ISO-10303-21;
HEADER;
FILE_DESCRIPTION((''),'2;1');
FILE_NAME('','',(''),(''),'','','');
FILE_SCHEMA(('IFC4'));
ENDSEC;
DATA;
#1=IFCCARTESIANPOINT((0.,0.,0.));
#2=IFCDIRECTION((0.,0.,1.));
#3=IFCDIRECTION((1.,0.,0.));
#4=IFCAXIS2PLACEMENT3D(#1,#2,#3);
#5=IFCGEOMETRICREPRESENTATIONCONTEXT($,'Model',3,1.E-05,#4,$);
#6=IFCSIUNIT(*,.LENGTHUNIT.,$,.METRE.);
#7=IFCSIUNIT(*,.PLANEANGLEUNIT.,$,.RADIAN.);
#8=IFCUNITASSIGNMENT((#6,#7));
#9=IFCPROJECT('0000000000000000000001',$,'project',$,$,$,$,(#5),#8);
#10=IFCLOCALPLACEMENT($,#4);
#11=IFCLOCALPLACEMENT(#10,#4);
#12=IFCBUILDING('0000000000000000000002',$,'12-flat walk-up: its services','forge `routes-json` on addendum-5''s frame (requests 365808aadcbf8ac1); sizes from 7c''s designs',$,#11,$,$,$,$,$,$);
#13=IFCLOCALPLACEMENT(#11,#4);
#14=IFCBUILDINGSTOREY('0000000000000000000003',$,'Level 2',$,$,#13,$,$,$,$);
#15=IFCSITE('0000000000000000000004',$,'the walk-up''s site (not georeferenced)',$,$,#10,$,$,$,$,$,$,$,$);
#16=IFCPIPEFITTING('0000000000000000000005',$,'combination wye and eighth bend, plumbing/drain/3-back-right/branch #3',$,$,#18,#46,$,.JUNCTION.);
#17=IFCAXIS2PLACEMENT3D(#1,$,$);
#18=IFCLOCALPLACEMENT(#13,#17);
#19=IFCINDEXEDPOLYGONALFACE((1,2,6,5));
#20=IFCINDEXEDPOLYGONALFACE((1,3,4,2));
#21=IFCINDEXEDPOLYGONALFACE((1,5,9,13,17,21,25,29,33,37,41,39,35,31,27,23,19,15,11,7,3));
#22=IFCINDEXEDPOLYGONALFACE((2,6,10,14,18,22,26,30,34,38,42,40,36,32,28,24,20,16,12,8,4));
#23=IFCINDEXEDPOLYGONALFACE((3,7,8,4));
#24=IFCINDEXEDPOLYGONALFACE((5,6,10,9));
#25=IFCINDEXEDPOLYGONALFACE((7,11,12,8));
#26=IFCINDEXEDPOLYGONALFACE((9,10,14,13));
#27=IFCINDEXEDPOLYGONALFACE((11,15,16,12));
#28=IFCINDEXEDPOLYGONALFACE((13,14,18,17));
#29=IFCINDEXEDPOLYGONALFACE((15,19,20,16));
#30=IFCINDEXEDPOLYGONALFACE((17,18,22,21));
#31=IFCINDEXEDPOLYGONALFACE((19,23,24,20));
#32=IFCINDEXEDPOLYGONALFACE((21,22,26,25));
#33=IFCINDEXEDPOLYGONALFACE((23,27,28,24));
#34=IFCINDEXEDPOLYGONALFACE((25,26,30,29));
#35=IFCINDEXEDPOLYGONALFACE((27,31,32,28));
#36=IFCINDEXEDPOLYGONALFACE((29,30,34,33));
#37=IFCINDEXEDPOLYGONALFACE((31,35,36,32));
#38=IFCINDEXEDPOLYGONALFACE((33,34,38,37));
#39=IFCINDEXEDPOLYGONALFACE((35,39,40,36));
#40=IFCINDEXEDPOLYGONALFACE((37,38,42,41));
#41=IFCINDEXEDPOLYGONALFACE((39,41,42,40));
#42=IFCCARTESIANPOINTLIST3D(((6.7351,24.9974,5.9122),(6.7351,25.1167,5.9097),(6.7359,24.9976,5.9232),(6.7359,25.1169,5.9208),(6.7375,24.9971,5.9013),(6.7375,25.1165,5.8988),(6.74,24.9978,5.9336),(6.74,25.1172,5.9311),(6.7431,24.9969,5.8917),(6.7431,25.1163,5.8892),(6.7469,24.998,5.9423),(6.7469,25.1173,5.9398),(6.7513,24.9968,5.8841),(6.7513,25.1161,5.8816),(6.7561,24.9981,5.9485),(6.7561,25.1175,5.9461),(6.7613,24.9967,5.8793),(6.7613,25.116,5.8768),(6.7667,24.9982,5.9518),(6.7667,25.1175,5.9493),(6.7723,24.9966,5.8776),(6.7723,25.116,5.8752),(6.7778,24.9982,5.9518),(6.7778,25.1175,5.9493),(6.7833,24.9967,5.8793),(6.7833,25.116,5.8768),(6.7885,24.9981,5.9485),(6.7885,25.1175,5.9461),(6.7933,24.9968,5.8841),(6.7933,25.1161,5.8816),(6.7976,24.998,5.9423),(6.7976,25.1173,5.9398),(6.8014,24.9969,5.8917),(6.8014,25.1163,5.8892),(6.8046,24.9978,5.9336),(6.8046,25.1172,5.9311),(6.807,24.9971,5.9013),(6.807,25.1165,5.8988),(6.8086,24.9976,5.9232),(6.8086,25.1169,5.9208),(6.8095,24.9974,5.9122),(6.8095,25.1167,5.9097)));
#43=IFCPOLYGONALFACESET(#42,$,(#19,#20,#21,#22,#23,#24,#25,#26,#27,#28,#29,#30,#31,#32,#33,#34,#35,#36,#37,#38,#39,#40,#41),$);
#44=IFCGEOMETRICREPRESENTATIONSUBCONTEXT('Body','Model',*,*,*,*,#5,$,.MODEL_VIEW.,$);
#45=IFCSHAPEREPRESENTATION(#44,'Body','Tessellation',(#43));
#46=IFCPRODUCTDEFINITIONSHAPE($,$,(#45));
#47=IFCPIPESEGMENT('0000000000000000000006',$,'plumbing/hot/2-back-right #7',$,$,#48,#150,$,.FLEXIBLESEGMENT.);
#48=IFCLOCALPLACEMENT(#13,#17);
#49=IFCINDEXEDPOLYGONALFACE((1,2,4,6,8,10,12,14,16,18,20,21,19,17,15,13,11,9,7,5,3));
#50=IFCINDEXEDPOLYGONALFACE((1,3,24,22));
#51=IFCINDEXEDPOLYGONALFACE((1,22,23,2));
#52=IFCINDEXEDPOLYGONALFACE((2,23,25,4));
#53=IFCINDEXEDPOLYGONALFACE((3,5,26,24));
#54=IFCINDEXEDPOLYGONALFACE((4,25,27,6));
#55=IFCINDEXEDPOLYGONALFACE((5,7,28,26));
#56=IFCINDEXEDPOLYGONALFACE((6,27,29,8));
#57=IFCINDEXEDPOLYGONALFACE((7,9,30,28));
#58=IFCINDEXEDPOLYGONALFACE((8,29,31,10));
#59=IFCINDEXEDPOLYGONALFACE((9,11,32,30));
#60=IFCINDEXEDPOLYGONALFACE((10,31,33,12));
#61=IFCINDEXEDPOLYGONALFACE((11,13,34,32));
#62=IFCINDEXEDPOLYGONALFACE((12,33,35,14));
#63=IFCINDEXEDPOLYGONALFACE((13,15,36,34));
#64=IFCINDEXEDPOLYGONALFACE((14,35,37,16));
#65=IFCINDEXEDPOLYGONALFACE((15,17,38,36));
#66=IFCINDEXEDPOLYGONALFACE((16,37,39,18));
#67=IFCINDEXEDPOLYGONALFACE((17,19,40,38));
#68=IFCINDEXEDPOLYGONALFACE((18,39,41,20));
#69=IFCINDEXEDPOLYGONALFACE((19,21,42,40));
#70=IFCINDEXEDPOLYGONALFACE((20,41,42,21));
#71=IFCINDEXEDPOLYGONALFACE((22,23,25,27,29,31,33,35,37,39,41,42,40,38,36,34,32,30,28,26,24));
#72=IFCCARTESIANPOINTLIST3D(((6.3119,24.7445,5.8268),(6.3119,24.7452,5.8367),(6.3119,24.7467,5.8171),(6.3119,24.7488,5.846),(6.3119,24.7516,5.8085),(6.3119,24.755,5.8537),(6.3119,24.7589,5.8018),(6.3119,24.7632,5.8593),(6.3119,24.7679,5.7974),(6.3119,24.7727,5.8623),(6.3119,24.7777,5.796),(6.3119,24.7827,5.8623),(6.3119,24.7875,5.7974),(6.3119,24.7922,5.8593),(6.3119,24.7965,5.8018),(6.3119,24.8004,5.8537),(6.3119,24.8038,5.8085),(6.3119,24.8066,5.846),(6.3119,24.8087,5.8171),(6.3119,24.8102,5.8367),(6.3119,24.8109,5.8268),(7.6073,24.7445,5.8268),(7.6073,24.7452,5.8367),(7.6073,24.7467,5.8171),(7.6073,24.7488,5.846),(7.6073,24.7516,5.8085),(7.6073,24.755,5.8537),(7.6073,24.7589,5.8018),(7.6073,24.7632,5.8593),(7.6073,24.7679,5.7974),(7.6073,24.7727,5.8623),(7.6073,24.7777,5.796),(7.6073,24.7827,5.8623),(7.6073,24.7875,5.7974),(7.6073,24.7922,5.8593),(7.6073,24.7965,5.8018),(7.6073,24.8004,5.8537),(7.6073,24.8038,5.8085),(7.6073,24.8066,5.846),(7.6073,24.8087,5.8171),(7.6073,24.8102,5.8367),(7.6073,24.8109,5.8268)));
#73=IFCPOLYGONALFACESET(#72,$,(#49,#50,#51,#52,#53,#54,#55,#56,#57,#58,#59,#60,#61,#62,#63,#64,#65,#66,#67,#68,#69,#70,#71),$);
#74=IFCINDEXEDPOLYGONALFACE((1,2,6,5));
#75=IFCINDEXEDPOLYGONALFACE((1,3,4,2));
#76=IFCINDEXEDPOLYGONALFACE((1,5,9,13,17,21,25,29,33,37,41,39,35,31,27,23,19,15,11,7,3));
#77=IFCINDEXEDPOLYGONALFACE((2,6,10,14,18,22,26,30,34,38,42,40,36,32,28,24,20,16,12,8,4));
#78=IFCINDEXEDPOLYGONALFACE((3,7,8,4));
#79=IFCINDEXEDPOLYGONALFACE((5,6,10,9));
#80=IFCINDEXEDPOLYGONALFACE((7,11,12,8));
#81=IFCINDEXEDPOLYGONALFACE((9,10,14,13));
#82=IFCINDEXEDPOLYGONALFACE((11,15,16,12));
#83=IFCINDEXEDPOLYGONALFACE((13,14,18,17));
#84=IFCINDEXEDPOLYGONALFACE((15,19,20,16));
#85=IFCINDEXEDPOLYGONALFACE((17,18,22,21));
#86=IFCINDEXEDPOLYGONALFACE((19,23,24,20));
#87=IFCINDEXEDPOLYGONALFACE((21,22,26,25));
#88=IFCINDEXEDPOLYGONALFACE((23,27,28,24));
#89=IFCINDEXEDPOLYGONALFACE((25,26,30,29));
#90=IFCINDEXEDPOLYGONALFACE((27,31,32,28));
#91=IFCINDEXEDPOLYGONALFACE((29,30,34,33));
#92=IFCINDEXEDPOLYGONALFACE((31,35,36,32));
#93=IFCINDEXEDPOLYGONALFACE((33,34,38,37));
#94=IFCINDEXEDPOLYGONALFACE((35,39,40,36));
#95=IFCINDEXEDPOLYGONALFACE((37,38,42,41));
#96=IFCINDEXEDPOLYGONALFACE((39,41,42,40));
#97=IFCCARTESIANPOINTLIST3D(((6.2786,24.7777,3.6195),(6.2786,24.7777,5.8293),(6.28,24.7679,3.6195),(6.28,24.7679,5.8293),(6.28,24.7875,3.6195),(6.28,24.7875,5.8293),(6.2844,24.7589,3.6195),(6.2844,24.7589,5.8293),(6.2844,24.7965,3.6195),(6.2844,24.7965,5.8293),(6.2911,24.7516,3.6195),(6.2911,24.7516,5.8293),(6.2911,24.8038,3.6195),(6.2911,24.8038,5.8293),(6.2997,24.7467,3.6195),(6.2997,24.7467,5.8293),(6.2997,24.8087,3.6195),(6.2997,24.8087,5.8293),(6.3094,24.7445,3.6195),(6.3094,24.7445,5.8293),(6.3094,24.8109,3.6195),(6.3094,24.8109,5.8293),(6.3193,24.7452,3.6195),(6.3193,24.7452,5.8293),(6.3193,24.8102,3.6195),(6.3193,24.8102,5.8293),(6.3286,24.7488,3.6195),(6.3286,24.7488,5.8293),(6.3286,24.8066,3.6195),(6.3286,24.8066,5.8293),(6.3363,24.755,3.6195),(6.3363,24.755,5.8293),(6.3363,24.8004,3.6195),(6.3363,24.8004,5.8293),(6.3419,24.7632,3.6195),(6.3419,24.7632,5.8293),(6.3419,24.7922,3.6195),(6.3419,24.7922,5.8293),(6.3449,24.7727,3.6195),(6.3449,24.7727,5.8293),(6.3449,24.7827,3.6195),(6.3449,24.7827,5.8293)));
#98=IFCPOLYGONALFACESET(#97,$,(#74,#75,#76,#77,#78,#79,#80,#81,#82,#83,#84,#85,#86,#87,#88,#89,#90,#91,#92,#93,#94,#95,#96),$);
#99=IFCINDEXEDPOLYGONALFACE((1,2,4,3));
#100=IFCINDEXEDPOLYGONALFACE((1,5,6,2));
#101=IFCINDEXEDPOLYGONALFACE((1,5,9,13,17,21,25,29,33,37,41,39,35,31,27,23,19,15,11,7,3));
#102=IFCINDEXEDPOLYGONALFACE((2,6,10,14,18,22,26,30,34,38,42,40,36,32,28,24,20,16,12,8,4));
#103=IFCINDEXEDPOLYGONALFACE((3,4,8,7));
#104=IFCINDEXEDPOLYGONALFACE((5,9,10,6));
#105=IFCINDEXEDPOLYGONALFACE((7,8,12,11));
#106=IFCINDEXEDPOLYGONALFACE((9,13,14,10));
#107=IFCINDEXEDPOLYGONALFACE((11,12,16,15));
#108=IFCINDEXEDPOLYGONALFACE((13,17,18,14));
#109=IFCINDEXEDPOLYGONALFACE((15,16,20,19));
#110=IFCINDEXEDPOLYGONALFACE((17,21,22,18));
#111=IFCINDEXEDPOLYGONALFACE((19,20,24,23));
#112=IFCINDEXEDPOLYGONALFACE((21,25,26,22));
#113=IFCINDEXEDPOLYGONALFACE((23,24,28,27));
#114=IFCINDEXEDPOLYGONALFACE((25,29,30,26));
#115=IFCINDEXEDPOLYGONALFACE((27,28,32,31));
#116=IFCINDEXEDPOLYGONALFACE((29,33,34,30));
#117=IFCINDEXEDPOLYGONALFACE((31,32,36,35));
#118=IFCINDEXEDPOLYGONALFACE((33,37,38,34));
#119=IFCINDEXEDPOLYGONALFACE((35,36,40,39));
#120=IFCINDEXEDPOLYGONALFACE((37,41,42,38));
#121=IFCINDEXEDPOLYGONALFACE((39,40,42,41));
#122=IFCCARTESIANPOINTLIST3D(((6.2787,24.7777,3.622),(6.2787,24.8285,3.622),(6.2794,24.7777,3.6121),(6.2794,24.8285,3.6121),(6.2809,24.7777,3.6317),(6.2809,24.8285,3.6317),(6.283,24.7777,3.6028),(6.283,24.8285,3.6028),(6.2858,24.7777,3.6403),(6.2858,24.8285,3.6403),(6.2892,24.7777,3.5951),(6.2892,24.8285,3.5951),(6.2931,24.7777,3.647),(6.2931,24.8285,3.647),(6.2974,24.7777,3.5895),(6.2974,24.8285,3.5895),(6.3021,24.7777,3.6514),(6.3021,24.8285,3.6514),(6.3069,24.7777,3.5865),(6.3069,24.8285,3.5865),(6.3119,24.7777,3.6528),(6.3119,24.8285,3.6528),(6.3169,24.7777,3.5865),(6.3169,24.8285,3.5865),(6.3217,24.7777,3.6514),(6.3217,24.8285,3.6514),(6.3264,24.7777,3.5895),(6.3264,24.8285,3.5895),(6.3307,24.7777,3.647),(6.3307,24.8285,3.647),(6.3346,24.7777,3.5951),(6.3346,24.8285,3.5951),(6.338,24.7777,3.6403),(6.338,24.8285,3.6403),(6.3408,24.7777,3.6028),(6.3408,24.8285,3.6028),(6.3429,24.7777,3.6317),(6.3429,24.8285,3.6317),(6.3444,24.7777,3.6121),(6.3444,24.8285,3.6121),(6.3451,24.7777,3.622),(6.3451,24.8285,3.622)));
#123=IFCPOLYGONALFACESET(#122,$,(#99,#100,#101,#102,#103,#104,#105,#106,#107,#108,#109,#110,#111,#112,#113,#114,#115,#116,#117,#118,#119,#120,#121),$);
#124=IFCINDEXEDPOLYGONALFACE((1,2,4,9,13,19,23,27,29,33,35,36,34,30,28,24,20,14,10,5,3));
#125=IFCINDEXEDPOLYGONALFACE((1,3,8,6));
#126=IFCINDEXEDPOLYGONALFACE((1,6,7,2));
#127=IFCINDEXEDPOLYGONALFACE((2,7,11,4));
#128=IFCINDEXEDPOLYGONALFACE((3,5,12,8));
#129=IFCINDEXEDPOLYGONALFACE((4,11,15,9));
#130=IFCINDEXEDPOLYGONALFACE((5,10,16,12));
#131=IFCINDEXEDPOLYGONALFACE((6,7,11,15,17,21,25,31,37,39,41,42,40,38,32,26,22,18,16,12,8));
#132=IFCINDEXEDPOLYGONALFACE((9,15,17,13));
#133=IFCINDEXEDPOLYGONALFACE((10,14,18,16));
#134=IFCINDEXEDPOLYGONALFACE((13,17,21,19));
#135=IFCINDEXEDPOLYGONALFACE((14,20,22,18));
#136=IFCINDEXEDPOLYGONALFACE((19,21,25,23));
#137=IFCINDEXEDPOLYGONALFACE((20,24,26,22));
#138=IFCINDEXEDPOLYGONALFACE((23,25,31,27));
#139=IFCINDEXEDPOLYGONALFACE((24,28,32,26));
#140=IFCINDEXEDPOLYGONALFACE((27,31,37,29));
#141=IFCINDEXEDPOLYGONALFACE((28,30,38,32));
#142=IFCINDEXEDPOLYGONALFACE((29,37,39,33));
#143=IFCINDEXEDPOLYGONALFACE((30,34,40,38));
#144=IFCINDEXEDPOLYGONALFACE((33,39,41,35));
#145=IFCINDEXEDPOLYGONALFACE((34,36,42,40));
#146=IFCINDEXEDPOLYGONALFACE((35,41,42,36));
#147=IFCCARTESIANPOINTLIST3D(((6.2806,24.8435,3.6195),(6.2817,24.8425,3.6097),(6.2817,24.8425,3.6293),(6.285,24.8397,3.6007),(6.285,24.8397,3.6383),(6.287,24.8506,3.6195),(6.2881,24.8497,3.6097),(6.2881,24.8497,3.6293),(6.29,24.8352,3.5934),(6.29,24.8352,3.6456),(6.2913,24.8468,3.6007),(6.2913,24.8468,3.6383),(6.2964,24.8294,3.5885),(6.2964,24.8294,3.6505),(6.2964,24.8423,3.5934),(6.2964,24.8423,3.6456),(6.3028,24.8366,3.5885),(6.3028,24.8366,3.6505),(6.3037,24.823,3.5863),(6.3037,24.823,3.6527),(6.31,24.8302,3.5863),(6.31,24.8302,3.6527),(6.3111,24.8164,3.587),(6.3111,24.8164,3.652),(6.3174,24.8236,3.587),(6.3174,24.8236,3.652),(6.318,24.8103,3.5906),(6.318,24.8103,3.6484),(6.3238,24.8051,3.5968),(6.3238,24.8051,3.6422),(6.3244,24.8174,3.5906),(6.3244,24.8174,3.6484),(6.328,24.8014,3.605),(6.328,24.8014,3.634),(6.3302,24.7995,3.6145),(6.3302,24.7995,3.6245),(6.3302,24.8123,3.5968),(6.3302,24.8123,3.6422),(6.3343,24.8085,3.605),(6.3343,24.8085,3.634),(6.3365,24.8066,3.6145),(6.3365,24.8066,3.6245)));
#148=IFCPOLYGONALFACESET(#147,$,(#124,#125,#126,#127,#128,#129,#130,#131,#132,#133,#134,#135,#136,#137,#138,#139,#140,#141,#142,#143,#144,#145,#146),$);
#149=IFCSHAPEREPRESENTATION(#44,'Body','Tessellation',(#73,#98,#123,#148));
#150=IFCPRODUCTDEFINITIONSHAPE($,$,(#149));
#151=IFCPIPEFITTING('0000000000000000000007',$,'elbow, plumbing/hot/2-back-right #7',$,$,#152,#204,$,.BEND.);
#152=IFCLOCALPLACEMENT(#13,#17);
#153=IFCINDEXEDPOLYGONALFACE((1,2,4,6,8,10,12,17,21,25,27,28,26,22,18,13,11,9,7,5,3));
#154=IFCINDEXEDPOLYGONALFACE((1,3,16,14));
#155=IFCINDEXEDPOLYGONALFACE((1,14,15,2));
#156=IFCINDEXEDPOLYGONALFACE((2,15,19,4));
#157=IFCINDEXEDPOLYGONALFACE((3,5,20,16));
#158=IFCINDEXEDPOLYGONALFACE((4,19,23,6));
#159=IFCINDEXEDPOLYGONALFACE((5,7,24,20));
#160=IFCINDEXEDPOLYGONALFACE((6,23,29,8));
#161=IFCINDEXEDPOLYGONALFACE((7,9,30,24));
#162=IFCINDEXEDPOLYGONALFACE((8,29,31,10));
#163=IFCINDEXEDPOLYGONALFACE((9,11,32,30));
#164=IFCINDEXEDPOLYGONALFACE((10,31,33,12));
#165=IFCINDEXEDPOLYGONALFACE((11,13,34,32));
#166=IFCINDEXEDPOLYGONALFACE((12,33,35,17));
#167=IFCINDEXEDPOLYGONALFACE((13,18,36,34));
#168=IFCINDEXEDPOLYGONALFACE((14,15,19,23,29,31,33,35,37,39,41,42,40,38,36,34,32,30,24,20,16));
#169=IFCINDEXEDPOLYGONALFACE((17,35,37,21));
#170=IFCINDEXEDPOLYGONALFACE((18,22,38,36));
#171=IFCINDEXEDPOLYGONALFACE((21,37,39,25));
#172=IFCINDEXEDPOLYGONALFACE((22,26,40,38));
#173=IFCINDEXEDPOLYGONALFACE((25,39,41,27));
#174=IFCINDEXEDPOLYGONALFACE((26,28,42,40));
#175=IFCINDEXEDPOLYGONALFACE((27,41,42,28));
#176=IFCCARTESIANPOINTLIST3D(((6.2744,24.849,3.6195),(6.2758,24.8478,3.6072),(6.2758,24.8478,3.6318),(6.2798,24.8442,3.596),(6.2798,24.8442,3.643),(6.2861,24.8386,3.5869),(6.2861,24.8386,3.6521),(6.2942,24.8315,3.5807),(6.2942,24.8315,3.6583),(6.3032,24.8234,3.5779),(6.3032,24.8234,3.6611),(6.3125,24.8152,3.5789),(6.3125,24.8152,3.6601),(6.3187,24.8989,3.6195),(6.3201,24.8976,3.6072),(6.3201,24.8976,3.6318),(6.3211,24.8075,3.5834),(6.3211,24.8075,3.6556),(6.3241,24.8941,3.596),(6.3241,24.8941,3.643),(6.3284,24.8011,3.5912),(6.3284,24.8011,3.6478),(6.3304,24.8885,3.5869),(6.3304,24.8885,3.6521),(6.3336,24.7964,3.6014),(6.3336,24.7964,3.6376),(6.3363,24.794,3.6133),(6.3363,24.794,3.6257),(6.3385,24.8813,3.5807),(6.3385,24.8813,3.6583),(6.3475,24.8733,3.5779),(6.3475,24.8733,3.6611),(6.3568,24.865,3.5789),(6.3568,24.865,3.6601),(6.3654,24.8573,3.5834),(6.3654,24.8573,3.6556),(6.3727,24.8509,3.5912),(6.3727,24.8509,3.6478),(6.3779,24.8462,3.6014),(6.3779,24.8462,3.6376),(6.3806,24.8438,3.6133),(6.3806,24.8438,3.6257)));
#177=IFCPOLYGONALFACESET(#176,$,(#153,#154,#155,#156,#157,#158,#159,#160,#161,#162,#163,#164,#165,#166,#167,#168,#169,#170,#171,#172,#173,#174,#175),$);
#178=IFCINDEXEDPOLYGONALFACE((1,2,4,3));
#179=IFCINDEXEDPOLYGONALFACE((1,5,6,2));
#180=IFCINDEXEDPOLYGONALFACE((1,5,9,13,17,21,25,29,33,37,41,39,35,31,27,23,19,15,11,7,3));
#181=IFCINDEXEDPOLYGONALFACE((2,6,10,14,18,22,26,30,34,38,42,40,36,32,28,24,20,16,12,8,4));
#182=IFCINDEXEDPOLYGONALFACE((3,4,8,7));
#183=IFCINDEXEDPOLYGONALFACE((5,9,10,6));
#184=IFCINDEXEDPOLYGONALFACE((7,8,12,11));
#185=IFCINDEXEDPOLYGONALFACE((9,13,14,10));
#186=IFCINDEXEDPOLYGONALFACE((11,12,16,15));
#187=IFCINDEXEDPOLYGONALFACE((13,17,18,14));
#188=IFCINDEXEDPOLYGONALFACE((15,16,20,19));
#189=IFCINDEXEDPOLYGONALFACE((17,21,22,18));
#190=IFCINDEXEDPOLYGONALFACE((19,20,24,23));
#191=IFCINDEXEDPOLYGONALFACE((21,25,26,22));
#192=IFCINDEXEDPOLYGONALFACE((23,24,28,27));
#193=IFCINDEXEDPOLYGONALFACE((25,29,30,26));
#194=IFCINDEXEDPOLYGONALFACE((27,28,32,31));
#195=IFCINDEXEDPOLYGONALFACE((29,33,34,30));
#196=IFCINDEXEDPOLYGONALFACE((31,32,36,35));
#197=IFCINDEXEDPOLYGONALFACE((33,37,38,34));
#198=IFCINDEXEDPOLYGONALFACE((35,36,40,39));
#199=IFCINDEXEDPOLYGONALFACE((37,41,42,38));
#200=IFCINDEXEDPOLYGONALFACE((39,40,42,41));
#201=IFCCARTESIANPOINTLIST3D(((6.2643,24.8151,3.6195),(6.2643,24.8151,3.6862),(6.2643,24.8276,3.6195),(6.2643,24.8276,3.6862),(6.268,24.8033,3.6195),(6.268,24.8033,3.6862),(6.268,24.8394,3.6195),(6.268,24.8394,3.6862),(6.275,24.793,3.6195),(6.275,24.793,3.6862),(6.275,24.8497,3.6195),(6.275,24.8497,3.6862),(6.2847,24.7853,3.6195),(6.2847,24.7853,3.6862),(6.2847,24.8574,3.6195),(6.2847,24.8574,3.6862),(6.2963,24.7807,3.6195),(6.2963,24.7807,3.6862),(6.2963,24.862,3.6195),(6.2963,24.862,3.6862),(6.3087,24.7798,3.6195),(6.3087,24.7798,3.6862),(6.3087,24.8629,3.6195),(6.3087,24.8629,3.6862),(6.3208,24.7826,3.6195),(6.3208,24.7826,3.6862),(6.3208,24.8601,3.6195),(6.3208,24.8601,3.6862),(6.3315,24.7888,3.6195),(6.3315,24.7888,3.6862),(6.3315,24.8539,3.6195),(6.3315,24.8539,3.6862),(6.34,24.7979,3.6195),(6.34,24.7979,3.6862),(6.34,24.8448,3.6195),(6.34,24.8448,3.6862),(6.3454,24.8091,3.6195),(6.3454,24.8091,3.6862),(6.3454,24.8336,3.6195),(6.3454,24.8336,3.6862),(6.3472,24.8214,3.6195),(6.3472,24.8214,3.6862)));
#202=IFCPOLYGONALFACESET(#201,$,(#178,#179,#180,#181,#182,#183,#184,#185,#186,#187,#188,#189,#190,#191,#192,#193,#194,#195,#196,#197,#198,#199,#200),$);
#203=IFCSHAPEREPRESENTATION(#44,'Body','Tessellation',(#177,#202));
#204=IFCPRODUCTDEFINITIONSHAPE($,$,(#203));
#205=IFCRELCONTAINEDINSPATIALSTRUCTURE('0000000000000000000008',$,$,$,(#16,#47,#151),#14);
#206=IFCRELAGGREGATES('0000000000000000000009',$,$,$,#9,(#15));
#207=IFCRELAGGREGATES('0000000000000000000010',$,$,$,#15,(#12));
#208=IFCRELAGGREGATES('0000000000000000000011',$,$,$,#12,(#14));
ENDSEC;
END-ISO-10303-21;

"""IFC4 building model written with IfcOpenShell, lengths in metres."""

from ifc_helpers import new_model, entity, si_unit, frame, origin_with_axes, place, context, subcontext, project, spatial, element, save


model = new_model("IFC4")

# Units and contexts
model_context = context("Model", 3, precision=1e-05, world=origin_with_axes())
body_context = subcontext(model_context, "Body", "Model", "MODEL_VIEW")
ifc_project = project(units=[si_unit("LENGTHUNIT", "METRE"), si_unit("PLANEANGLEUNIT", "RADIAN")], contexts=[model_context])

# Site, building, storey
site_placement = place(None, origin_with_axes())
site = spatial("IfcSite", under=ifc_project, at=site_placement, Name="the walk-up's site (not georeferenced)")
building_placement = place(site_placement, origin_with_axes())
building = spatial("IfcBuilding", under=site, at=building_placement, Name="12-flat walk-up: its services", Description="forge `routes-json` on addendum-5's frame (requests 365808aadcbf8ac1); sizes from 7c's designs")
storey_placement = place(building_placement, origin_with_axes())
storey = spatial("IfcBuildingStorey", under=building, at=storey_placement, Name="Level 2")

# Pipe fitting
pipe_fitting_1_placement = place(storey_placement, frame((6.7723, 25.1168, 5.9125), z_axis=(0.0, 0.0, 1.0), x_axis=(1.0, 0.0, 0.0)))
element("IfcPipeFitting", 1, at=pipe_fitting_1_placement, inside=storey, Name="combination wye and eighth bend, plumbing/drain/3-back-right/branch #3", PredefinedType="JUNCTION", context=body_context, shape_type="AdvancedSweptSolid", body=[
    entity("IfcSweptDiskSolid", entity("IfcPolyline", [entity("IfcCartesianPoint", [0.0, 0.0, 0.0]), entity("IfcCartesianPoint", [0.0, -0.1194, 0.0025])]), 0.0373),
])

# Pipe segment
pipe_segment_1_placement = place(storey_placement, frame((7.6073, 24.7777, 5.8293), z_axis=(0.0, 0.0, 1.0), x_axis=(1.0, 0.0, 0.0)))
element("IfcPipeSegment", 2, at=pipe_segment_1_placement, inside=storey, Name="plumbing/hot/2-back-right #7", PredefinedType="FLEXIBLESEGMENT", context=body_context, shape_type="AdvancedSweptSolid", body=[
    entity("IfcSweptDiskSolid", entity("IfcPolyline", [entity("IfcCartesianPoint", [0.0, 0.0, 0.0]), entity("IfcCartesianPoint", [-1.2954, 0.0, 0.0])]), 0.0333),
    entity("IfcSweptDiskSolid", entity("IfcPolyline", [entity("IfcCartesianPoint", [-1.2954, 0.0, 0.0]), entity("IfcCartesianPoint", [-1.2954, 0.0, -2.2098])]), 0.0333),
    entity("IfcSweptDiskSolid", entity("IfcPolyline", [entity("IfcCartesianPoint", [-1.2954, 0.0, -2.2098]), entity("IfcCartesianPoint", [-1.2954, 0.0508, -2.2098])]), 0.0333),
    entity("IfcSweptDiskSolid", entity("IfcPolyline", [entity("IfcCartesianPoint", [-1.2954, 0.0508, -2.2098]), entity("IfcCartesianPoint", [-1.3017, 0.0437, -2.2098])]), 0.0333),
])

# Pipe fitting
pipe_fitting_2_placement = place(storey_placement, frame((6.3498, 24.8712, 3.6195), z_axis=(0.0, 0.0, 1.0), x_axis=(1.0, 0.0, 0.0)))
element("IfcPipeFitting", 3, at=pipe_fitting_2_placement, inside=storey, Name="elbow, plumbing/hot/2-back-right #7", PredefinedType="BEND", context=body_context, shape_type="AdvancedSweptSolid", body=[
    entity("IfcSweptDiskSolid", entity("IfcPolyline", [entity("IfcCartesianPoint", [0.0, 0.0, 0.0]), entity("IfcCartesianPoint", [-0.0443, -0.0498, 0.0])]), 0.0417),
    entity("IfcSweptDiskSolid", entity("IfcPolyline", [entity("IfcCartesianPoint", [-0.0443, -0.0498, 0.0]), entity("IfcCartesianPoint", [-0.0443, -0.0498, 0.0667])]), 0.0417),
])

save(model, "model.ifc")
